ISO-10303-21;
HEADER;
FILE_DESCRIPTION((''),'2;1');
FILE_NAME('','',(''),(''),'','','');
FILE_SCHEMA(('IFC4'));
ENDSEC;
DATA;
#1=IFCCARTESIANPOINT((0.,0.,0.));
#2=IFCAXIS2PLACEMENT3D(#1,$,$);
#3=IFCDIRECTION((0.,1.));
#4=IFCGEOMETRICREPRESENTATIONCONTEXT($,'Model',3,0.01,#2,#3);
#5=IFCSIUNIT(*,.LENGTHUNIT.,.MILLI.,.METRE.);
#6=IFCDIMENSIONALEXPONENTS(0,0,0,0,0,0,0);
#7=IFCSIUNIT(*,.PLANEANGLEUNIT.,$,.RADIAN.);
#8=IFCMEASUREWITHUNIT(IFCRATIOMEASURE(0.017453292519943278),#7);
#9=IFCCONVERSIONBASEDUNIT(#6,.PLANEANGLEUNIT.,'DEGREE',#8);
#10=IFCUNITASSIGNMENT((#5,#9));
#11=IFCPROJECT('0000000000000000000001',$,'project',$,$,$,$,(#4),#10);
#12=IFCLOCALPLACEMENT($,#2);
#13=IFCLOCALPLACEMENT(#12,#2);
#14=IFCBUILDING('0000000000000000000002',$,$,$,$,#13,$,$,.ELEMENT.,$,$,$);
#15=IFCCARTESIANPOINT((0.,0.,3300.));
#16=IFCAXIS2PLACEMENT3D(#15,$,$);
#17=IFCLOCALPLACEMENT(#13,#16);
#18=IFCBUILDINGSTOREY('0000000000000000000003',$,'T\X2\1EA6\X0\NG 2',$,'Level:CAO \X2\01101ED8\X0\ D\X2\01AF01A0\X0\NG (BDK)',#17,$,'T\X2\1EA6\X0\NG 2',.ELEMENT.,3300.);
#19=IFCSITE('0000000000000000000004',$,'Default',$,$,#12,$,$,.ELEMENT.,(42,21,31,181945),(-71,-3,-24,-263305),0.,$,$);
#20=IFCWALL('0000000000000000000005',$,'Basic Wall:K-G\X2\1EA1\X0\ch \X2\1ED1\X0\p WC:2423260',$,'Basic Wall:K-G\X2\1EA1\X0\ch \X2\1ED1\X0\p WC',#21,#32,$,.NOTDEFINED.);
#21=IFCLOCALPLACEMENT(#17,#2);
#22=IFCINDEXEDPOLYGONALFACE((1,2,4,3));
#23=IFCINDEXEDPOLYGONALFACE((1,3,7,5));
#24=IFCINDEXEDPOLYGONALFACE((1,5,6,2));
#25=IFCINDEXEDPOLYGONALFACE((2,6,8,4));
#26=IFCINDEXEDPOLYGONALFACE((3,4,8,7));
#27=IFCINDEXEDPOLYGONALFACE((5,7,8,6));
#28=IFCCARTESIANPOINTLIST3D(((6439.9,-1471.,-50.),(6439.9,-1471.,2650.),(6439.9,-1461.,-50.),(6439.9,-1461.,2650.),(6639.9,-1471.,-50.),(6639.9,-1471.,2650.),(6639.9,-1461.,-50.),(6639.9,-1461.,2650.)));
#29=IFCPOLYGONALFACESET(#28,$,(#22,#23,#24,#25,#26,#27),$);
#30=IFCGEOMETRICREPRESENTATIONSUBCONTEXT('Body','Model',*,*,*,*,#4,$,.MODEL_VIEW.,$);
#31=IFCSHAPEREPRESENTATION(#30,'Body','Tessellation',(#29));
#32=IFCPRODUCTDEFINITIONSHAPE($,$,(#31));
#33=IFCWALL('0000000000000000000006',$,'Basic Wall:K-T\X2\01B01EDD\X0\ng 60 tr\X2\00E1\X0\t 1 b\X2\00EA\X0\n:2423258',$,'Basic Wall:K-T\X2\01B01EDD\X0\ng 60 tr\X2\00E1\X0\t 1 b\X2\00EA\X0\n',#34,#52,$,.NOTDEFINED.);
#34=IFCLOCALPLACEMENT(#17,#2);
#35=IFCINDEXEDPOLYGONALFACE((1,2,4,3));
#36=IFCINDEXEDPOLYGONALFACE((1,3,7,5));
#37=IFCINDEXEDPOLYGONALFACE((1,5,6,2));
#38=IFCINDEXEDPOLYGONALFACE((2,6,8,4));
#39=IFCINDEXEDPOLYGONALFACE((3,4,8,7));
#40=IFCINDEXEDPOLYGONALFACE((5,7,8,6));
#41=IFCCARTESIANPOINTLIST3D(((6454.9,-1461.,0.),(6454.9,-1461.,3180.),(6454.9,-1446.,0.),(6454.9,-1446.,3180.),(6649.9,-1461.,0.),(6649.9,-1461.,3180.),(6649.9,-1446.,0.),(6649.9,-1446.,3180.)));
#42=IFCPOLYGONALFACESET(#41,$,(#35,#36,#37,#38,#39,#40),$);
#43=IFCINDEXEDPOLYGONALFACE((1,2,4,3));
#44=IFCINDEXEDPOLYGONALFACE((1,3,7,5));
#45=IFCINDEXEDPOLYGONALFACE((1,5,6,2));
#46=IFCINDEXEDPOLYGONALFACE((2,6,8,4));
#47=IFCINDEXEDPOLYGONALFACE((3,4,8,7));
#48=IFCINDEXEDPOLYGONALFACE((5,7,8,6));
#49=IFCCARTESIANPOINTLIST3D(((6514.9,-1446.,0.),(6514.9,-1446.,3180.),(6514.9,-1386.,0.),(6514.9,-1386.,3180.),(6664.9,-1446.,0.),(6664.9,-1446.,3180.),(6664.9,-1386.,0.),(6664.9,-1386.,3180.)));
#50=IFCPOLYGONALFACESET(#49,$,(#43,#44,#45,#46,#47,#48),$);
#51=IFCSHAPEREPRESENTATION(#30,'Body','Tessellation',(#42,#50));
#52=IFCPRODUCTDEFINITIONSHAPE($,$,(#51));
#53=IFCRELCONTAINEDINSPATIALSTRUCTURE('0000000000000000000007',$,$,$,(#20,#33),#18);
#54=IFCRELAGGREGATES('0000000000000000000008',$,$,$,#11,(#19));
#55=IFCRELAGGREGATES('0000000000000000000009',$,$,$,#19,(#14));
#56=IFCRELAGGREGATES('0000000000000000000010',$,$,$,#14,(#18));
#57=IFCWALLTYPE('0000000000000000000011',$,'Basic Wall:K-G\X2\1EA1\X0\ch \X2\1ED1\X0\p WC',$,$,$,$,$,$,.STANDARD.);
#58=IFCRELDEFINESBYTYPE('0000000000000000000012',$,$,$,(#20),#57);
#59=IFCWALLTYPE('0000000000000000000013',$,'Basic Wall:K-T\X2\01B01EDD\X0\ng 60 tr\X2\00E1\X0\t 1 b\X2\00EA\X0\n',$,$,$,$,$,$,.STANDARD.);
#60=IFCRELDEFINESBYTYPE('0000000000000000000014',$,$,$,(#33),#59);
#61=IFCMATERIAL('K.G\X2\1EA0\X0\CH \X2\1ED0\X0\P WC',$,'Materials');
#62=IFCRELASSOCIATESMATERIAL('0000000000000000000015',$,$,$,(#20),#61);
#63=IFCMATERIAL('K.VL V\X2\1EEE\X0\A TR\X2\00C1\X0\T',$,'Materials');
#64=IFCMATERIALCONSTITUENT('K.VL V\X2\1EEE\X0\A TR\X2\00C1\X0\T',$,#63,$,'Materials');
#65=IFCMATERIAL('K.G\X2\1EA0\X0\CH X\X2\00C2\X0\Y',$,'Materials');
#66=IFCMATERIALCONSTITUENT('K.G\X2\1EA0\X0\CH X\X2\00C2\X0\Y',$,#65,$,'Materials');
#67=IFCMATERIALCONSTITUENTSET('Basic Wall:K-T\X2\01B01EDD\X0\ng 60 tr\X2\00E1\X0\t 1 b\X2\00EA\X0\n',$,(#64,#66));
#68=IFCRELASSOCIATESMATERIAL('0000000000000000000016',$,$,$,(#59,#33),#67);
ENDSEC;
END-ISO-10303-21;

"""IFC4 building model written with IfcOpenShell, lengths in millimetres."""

from ifc_helpers import new_model, entity, si_unit, converted_unit, direction, frame, origin, place, context, subcontext, project, spatial, indexed_curve, outline, extrude, material, constituent, constituent_set, type_object, element, save


model = new_model("IFC4")

# Units and contexts
model_context = context("Model", 3, precision=0.01, world=origin(), true_north=direction((0.0, 1.0)))
body_context = subcontext(model_context, "Body", "Model", "MODEL_VIEW")
ifc_project = project(units=[si_unit("LENGTHUNIT", "METRE", prefix="MILLI"), converted_unit("PLANEANGLEUNIT", "DEGREE", entity("IfcRatioMeasure", 0.017453292519943278), si_unit("PLANEANGLEUNIT", "RADIAN"), dimensions=[0, 0, 0, 0, 0, 0, 0])], contexts=[model_context])

# Site, building, storey
site_placement = place(None, origin())
site = spatial("IfcSite", under=ifc_project, at=site_placement, Name="Default", CompositionType="ELEMENT", RefLatitude=(42, 21, 31, 181945), RefLongitude=(-71, -3, -24, -263305), RefElevation=0.0)
building_placement = place(site_placement, origin())
building = spatial("IfcBuilding", under=site, at=building_placement, CompositionType="ELEMENT")
storey_placement = place(building_placement, frame((0.0, 0.0, 3300.0)))
storey = spatial("IfcBuildingStorey", under=building, at=storey_placement, Name="TẦNG 2", ObjectType="Level:CAO ĐỘ DƯƠNG (BDK)", LongName="TẦNG 2", CompositionType="ELEMENT", Elevation=3300.0)

# Shared definitions
ifc_material_1 = material(Name="K.VL VỮA TRÁT", Category="Materials")
ifc_material_2 = material(Name="K.GẠCH XÂY", Category="Materials")

# Walls
ifc_material_3 = material(Name="K.GẠCH ỐP WC", Category="Materials")
wall_type_1 = type_object("IfcWallType", Name="Basic Wall:K-Gạch ốp WC", PredefinedType="STANDARD")
wall_1_placement = place(storey_placement, frame((6439.9, -1466.0, -50.0)))
element("IfcWall", 1, at=wall_1_placement, inside=storey, type_object=wall_type_1, material=ifc_material_3, Name="Basic Wall:K-Gạch ốp WC:2423260", ObjectType="Basic Wall:K-Gạch ốp WC", PredefinedType="NOTDEFINED", context=body_context, shape_type="SweptSolid", body=[
    extrude(outline(indexed_curve([(200.0, 5.0), (0.0, 5.0), (0.0, -5.0), (200.0, -5.0), (200.0, 5.0)], self_intersect=False)), origin(), (0.0, 0.0, 1.0), 2700.0),
])
ifc_constituent_1 = constituent(ifc_material_1, Name="K.VL VỮA TRÁT", Category="Materials")
ifc_constituent_2 = constituent(ifc_material_2, Name="K.GẠCH XÂY", Category="Materials")
ifc_constituent_set_1 = constituent_set(constituents=[ifc_constituent_1, ifc_constituent_2], Name="Basic Wall:K-Tường 60 trát 1 bên")
wall_type_2 = type_object("IfcWallType", Name="Basic Wall:K-Tường 60 trát 1 bên", PredefinedType="STANDARD", material=ifc_constituent_set_1)
wall_2_placement = place(storey_placement, frame((6514.9, -1423.5, 0.0)))
element("IfcWall", 2, at=wall_2_placement, inside=storey, type_object=wall_type_2, material=ifc_constituent_set_1, Name="Basic Wall:K-Tường 60 trát 1 bên:2423258", ObjectType="Basic Wall:K-Tường 60 trát 1 bên", PredefinedType="NOTDEFINED", context=body_context, shape_type="SweptSolid", body=[
    extrude(outline(indexed_curve([(-7.5, -97.5), (7.5, -97.5), (7.5, 97.5), (-7.5, 97.5), (-7.5, -97.5)], self_intersect=False)), frame((37.5, -30.0, 0.0), z_axis=(0.0, 0.0, 1.0), x_axis=(0.0, 1.0, 0.0)), (0.0, 0.0, 1.0), 3180.0),
    extrude(outline(indexed_curve([(-30.0, -75.0), (30.0, -75.0), (30.0, 75.0), (-30.0, 75.0), (-30.0, -75.0)], self_intersect=False)), frame((75.0, 7.5, 0.0), z_axis=(0.0, 0.0, 1.0), x_axis=(0.0, -1.0, 0.0)), (0.0, 0.0, 1.0), 3180.0),
])

save(model, "model.ifc")
